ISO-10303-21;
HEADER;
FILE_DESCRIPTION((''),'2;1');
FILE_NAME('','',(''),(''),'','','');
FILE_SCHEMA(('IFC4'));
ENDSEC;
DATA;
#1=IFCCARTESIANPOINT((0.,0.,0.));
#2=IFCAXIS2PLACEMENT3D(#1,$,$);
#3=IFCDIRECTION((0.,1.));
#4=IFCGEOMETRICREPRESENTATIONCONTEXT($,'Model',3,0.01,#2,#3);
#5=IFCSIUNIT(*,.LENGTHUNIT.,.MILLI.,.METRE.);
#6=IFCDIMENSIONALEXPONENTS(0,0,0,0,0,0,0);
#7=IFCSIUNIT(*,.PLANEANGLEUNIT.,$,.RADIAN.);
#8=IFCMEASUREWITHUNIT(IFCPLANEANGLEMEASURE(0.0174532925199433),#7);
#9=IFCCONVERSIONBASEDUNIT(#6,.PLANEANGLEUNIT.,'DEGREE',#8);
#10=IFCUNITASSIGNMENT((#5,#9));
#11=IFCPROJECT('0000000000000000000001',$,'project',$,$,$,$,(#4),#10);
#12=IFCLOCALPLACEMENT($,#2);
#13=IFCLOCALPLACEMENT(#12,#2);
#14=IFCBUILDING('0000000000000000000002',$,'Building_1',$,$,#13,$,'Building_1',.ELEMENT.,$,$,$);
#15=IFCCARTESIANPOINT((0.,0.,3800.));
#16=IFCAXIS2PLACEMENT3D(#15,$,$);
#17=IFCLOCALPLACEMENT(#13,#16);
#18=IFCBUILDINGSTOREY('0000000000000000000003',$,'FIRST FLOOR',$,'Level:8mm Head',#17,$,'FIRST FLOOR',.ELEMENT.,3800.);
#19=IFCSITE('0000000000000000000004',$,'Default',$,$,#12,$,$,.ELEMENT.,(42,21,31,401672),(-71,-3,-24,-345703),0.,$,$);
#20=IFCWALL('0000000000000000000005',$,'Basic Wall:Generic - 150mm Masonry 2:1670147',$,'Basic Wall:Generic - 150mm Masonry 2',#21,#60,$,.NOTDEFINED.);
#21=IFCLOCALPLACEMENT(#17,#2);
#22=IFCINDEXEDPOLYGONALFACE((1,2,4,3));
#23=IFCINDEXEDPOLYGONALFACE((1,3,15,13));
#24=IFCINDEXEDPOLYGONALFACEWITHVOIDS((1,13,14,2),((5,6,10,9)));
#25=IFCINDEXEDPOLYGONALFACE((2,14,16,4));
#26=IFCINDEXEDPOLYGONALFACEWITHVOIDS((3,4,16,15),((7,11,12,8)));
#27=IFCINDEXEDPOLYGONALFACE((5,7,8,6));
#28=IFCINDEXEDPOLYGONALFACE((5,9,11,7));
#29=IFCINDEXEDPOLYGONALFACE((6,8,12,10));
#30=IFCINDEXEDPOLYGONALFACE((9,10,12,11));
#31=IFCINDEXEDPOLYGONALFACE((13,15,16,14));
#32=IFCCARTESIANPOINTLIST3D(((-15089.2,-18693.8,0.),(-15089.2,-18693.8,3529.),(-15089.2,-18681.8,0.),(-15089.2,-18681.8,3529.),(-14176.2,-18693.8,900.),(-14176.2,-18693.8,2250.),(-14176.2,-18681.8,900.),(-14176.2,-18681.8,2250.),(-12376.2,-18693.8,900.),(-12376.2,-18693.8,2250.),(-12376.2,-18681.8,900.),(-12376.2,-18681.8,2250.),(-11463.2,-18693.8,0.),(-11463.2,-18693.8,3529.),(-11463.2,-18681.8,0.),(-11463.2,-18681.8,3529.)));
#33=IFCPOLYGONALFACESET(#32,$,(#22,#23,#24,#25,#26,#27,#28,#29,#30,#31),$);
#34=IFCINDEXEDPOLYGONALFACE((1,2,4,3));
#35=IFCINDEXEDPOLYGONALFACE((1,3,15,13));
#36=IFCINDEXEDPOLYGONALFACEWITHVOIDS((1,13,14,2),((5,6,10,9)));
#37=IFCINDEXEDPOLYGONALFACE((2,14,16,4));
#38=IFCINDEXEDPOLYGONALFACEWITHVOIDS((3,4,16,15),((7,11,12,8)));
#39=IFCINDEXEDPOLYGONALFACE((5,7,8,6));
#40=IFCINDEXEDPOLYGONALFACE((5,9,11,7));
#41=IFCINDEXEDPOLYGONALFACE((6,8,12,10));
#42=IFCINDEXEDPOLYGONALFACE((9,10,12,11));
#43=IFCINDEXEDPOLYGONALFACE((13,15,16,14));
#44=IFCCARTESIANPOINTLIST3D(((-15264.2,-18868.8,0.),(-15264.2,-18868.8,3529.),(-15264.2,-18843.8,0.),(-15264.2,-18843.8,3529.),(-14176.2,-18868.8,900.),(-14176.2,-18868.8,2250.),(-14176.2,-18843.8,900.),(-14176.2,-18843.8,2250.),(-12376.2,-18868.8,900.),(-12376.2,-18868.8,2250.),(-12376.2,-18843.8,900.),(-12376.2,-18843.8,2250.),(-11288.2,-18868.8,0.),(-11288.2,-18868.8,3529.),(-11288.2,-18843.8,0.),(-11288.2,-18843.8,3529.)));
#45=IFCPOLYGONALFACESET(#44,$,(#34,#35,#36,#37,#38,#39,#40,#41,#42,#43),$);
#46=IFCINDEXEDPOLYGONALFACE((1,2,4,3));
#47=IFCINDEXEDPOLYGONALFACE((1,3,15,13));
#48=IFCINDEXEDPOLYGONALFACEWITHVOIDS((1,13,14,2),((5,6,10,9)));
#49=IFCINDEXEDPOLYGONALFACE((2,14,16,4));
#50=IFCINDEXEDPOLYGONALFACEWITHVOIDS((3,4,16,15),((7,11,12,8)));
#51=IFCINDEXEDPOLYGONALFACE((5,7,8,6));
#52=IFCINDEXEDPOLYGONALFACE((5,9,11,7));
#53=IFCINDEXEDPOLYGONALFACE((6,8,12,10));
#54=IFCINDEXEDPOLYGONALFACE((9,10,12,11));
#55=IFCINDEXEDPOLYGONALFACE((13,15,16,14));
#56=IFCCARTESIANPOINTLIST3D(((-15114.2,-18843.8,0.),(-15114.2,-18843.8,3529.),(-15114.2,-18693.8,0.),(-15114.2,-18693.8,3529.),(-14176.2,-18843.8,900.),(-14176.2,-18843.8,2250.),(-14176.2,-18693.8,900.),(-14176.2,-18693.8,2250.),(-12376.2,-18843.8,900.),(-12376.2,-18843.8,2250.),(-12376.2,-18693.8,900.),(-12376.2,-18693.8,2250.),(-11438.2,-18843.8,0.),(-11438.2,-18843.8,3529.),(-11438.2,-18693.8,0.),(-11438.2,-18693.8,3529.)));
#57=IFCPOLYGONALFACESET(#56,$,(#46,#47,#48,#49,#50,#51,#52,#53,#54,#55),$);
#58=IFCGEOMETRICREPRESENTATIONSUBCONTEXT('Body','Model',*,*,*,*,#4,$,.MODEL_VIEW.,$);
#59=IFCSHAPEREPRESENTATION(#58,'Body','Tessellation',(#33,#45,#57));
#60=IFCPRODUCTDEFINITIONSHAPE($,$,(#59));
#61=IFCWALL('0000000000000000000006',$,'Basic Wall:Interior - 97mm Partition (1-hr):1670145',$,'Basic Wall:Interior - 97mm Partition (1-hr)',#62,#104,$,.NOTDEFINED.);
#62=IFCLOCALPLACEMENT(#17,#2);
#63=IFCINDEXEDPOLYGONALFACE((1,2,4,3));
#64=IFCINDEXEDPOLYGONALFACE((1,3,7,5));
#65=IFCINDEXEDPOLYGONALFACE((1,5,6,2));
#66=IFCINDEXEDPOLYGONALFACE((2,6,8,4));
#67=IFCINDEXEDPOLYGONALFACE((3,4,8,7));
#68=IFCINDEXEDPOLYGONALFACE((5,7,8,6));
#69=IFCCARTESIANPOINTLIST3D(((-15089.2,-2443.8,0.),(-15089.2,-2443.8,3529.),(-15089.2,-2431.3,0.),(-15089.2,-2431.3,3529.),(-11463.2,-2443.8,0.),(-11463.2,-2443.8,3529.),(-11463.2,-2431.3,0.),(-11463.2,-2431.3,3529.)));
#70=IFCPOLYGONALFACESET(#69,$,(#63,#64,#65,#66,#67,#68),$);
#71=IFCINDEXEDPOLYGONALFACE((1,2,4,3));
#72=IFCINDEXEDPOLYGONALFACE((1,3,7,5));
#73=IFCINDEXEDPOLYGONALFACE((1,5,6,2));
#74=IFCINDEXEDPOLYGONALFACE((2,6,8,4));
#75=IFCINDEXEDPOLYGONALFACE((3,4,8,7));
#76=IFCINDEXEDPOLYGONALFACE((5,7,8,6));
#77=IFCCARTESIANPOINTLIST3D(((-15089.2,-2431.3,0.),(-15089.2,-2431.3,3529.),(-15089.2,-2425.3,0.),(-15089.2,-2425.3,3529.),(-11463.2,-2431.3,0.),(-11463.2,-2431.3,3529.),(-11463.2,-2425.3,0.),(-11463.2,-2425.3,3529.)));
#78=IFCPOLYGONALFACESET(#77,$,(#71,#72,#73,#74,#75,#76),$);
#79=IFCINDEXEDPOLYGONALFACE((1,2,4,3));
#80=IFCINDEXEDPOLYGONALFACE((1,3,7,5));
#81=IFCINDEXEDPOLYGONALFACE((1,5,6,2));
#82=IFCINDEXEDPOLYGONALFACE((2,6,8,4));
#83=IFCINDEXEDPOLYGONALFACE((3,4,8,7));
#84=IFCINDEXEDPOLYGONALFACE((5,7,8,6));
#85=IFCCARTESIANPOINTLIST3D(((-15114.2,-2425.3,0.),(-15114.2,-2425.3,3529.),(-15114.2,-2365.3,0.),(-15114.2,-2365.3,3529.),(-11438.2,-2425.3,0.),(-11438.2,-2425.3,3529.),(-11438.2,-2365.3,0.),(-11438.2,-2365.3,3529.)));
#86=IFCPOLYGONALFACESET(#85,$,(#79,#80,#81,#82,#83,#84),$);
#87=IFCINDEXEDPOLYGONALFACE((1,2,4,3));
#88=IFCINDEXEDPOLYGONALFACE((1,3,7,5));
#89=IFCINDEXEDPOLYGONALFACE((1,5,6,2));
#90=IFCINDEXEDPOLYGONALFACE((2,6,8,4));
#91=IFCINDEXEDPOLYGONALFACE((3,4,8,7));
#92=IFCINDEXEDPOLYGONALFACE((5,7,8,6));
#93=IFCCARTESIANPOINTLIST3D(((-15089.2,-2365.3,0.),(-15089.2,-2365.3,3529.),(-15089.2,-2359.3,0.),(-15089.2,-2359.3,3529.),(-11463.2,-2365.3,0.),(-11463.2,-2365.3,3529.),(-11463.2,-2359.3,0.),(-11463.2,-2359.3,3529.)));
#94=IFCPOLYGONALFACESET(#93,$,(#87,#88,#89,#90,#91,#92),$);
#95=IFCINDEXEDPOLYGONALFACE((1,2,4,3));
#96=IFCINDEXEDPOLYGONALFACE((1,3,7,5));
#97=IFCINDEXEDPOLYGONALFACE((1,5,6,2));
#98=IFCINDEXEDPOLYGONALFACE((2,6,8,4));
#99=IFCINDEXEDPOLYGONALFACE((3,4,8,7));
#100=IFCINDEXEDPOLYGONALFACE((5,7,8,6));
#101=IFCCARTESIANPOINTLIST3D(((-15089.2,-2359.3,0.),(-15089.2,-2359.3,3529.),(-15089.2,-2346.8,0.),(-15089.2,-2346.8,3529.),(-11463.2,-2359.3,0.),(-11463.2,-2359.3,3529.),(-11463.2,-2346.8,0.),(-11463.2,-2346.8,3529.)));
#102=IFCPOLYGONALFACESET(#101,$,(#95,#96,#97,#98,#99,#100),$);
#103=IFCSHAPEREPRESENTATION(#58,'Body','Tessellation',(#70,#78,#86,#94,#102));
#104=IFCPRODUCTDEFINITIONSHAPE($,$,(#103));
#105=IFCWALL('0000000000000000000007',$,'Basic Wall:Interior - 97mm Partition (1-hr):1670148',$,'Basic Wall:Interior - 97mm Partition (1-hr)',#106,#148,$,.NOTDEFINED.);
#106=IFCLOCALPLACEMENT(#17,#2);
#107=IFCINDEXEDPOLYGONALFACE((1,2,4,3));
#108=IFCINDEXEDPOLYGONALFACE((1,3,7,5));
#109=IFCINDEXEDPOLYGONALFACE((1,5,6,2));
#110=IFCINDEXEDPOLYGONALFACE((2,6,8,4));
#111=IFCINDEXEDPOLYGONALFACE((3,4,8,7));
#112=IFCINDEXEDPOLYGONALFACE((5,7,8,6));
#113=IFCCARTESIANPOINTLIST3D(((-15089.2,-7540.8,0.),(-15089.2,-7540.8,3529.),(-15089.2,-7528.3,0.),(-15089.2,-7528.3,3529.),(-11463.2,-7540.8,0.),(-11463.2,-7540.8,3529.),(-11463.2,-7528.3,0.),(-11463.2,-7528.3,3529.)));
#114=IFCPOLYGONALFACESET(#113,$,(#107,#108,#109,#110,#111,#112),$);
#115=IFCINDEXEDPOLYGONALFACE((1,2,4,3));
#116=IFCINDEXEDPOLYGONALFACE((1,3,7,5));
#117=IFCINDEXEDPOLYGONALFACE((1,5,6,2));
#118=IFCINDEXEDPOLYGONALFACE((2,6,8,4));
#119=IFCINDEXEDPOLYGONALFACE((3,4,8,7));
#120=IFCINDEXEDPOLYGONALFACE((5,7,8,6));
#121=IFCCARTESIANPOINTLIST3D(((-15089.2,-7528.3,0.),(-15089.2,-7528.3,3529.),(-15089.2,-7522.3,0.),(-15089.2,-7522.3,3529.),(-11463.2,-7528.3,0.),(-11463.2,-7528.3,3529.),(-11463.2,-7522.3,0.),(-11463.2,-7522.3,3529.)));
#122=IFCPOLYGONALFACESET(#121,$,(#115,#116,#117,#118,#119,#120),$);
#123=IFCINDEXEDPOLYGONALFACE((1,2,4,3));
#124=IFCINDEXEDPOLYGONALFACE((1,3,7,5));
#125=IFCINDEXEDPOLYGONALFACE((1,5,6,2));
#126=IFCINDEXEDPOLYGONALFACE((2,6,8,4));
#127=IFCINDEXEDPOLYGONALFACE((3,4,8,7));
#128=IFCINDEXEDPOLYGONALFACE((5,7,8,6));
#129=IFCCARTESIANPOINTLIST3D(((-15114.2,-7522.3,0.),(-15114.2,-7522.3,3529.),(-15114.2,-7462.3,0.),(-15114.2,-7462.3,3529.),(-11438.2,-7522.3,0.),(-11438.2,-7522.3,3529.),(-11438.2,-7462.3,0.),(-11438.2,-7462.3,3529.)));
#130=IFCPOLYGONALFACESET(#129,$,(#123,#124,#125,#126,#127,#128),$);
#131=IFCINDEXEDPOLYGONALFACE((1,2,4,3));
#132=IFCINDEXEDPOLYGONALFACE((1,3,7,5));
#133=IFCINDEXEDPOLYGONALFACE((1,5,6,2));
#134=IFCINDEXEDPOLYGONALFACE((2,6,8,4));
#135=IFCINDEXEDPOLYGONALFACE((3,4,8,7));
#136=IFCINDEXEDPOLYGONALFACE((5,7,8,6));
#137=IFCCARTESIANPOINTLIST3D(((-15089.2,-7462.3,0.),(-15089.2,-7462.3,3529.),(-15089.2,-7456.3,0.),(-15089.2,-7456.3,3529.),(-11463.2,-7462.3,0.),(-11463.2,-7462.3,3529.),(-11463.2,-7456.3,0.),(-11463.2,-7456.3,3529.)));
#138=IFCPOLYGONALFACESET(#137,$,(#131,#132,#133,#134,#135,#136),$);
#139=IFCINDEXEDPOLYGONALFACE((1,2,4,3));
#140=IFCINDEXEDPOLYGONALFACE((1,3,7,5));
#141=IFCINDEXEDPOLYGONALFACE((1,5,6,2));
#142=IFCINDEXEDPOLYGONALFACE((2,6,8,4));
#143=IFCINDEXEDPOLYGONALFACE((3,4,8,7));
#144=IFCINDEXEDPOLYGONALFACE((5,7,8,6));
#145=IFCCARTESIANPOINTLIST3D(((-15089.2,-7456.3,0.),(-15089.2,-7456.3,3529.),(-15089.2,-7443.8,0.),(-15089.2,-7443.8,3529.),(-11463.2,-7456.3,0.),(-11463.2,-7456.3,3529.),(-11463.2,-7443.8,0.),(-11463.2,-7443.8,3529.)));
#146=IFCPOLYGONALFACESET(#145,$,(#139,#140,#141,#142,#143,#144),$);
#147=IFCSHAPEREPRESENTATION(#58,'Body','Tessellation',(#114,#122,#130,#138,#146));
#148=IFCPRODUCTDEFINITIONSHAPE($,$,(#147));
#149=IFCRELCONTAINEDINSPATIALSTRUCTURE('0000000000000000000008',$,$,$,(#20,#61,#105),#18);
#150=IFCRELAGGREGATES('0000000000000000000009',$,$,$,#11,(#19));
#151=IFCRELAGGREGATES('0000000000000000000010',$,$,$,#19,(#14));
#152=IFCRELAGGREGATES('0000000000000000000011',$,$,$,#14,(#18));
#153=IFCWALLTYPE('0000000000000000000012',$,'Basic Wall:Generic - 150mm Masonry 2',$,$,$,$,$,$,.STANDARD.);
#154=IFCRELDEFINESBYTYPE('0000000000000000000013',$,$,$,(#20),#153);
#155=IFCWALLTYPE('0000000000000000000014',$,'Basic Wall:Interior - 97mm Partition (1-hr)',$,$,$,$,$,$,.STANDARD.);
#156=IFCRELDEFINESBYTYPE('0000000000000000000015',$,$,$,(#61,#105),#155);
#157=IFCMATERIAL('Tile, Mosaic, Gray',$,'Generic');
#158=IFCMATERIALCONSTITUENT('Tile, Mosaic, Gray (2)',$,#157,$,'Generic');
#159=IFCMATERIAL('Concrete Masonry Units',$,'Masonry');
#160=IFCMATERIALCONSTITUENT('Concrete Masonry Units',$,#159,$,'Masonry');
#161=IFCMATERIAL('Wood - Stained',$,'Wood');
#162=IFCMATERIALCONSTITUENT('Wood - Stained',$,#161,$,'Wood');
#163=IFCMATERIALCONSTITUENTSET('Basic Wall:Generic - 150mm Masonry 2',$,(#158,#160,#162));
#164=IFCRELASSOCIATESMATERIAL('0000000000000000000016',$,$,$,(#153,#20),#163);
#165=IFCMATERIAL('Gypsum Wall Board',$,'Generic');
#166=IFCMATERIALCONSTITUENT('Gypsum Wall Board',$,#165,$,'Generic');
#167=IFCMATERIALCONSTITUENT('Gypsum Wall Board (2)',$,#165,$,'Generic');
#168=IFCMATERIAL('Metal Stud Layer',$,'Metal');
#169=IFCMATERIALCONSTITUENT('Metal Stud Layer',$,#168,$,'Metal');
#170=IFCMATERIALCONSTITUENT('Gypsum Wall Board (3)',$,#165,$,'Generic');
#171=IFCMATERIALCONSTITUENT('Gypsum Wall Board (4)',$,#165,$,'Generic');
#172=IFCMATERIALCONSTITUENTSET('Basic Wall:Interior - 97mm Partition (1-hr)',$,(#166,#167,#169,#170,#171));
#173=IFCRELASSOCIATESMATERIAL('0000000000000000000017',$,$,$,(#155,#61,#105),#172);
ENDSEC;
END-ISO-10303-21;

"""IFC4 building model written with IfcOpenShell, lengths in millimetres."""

from ifc_helpers import new_model, entity, si_unit, converted_unit, direction, frame, origin, place, context, subcontext, project, spatial, indexed_curve, outline, extrude, material, constituent, constituent_set, type_object, element, save


model = new_model("IFC4")

# Units and contexts
model_context = context("Model", 3, precision=0.01, world=origin(), true_north=direction((0.0, 1.0)))
body_context = subcontext(model_context, "Body", "Model", "MODEL_VIEW")
ifc_project = project(units=[si_unit("LENGTHUNIT", "METRE", prefix="MILLI"), converted_unit("PLANEANGLEUNIT", "DEGREE", entity("IfcPlaneAngleMeasure", 0.0174532925199433), si_unit("PLANEANGLEUNIT", "RADIAN"), dimensions=[0, 0, 0, 0, 0, 0, 0])], contexts=[model_context])

# Site, building, storey
site_placement = place(None, origin())
site = spatial("IfcSite", under=ifc_project, at=site_placement, Name="Default", CompositionType="ELEMENT", RefLatitude=(42, 21, 31, 401672), RefLongitude=(-71, -3, -24, -345703), RefElevation=0.0)
building_placement = place(site_placement, origin())
building = spatial("IfcBuilding", under=site, at=building_placement, Name="Building_1", LongName="Building_1", CompositionType="ELEMENT")
storey_placement = place(building_placement, frame((0.0, 0.0, 3800.0)))
storey = spatial("IfcBuildingStorey", under=building, at=storey_placement, Name="FIRST FLOOR", ObjectType="Level:8mm Head", LongName="FIRST FLOOR", CompositionType="ELEMENT", Elevation=3800.0)

# Shared definitions
ifc_material_1 = material(Name="Tile, Mosaic, Gray", Category="Generic")
ifc_constituent_1 = constituent(ifc_material_1, Name="Tile, Mosaic, Gray (2)", Category="Generic")
ifc_material_2 = material(Name="Concrete Masonry Units", Category="Masonry")
ifc_constituent_2 = constituent(ifc_material_2, Name="Concrete Masonry Units", Category="Masonry")
ifc_material_3 = material(Name="Wood - Stained", Category="Wood")
ifc_constituent_3 = constituent(ifc_material_3, Name="Wood - Stained", Category="Wood")
ifc_constituent_set_1 = constituent_set(constituents=[ifc_constituent_1, ifc_constituent_2, ifc_constituent_3], Name="Basic Wall:Generic - 150mm Masonry 2")
wall_type_1 = type_object("IfcWallType", Name="Basic Wall:Generic - 150mm Masonry 2", PredefinedType="STANDARD", material=ifc_constituent_set_1)

# Wall, opening
wall_1_placement = place(storey_placement, frame((-11463.2, -18775.3, 0.0), z_axis=(0.0, 0.0, 1.0), x_axis=(-1.0, 0.0, 0.0)))
wall_1 = element("IfcWall", 1, at=wall_1_placement, inside=storey, type_object=wall_type_1, material=ifc_constituent_set_1, Name="Basic Wall:Generic - 150mm Masonry 2:1670147", ObjectType="Basic Wall:Generic - 150mm Masonry 2", PredefinedType="NOTDEFINED", context=body_context, shape_type="SweptSolid", body=[
    extrude(outline(indexed_curve([(-1764.5, -1813.0), (1764.5, -1813.0), (1764.5, 1813.0), (-1764.5, 1813.0), (-1764.5, -1813.0)], self_intersect=False), holes=[indexed_curve([(-864.5, -900.0), (-864.5, 900.0), (485.5, 900.0), (485.5, -900.0), (-864.5, -900.0)], self_intersect=False)]), frame((1813.0, -81.5, 1764.5), z_axis=(0.0, -1.0, 0.0), x_axis=(0.0, 0.0, 1.0)), (0.0, 0.0, 1.0), 12.0),
    extrude(outline(indexed_curve([(-1988.0, -1764.5), (1988.0, -1764.5), (1988.0, 1764.5), (-1988.0, 1764.5), (-1988.0, -1764.5)], self_intersect=False), holes=[indexed_curve([(900.0, 485.5), (900.0, -864.5), (-900.0, -864.5), (-900.0, 485.5), (900.0, 485.5)], self_intersect=False)]), frame((1813.0, 93.5, 1764.5), z_axis=(0.0, -1.0, 0.0), x_axis=(1.0, 0.0, 0.0)), (0.0, 0.0, 1.0), 25.0),
    extrude(outline(indexed_curve([(-1764.5, -1838.0), (1764.5, -1838.0), (1764.5, 1838.0), (-1764.5, 1838.0), (-1764.5, -1838.0)], self_intersect=False), holes=[indexed_curve([(-864.5, -900.0), (-864.5, 900.0), (485.5, 900.0), (485.5, -900.0), (-864.5, -900.0)], self_intersect=False)]), frame((1813.0, 68.5, 1764.5), z_axis=(0.0, -1.0, 0.0), x_axis=(0.0, 0.0, 1.0)), (0.0, 0.0, 1.0), 150.0),
])
opening_placement = place(wall_1_placement, frame((913.0, -93.5, 900.0)))
element("IfcOpeningElement", 2, at=opening_placement, cuts=wall_1, PredefinedType="OPENING", context=body_context, shape_type="SweptSolid", body=[
    extrude(outline(indexed_curve([(1350.0, 1800.0), (0.0, 1800.0), (0.0, 0.0), (1350.0, 0.0), (1350.0, 1800.0)], self_intersect=False)), frame((0.0, 0.0, 0.0), z_axis=(0.0, 1.0, 0.0), x_axis=(0.0, 0.0, 1.0)), (0.0, 0.0, 1.0), 187.0),
])

# Walls
ifc_material_4 = material(Name="Gypsum Wall Board", Category="Generic")
ifc_constituent_4 = constituent(ifc_material_4, Name="Gypsum Wall Board", Category="Generic")
ifc_constituent_5 = constituent(ifc_material_4, Name="Gypsum Wall Board (2)", Category="Generic")
ifc_material_5 = material(Name="Metal Stud Layer", Category="Metal")
ifc_constituent_6 = constituent(ifc_material_5, Name="Metal Stud Layer", Category="Metal")
ifc_constituent_7 = constituent(ifc_material_4, Name="Gypsum Wall Board (3)", Category="Generic")
ifc_constituent_8 = constituent(ifc_material_4, Name="Gypsum Wall Board (4)", Category="Generic")
ifc_constituent_set_2 = constituent_set(constituents=[ifc_constituent_4, ifc_constituent_5, ifc_constituent_6, ifc_constituent_7, ifc_constituent_8], Name="Basic Wall:Interior - 97mm Partition (1-hr)")
wall_type_2 = type_object("IfcWallType", Name="Basic Wall:Interior - 97mm Partition (1-hr)", PredefinedType="STANDARD", material=ifc_constituent_set_2)
wall_2_placement = place(storey_placement, frame((-15089.2, -2395.3, 0.0)))
element("IfcWall", 3, at=wall_2_placement, inside=storey, type_object=wall_type_2, material=ifc_constituent_set_2, Name="Basic Wall:Interior - 97mm Partition (1-hr):1670145", ObjectType="Basic Wall:Interior - 97mm Partition (1-hr)", PredefinedType="NOTDEFINED", context=body_context, shape_type="SweptSolid", body=[
    extrude(outline(indexed_curve([(-6.3, -1813.0), (6.2, -1813.0), (6.3, 1813.0), (-6.2, 1813.0), (-6.3, -1813.0)], self_intersect=False)), frame((1813.0, -42.2, 0.0), z_axis=(0.0, 0.0, 1.0), x_axis=(0.0, 1.0, 0.0)), (0.0, 0.0, 1.0), 3529.0),
    extrude(outline(indexed_curve([(-1813.0, -3.0), (1813.0, -3.0), (1813.0, 3.0), (-1813.0, 3.0), (-1813.0, -3.0)], self_intersect=False)), frame((1813.0, -33.0, 0.0)), (0.0, 0.0, 1.0), 3529.0),
    extrude(outline(indexed_curve([(-1838.0, -30.0), (1838.0, -30.0), (1838.0, 30.0), (-1838.0, 30.0), (-1838.0, -30.0)], self_intersect=False)), frame((1813.0, 0.0, 0.0)), (0.0, 0.0, 1.0), 3529.0),
    extrude(outline(indexed_curve([(-1813.0, -3.0), (1813.0, -3.0), (1813.0, 3.0), (-1813.0, 3.0), (-1813.0, -3.0)], self_intersect=False)), frame((1813.0, 33.0, 0.0)), (0.0, 0.0, 1.0), 3529.0),
    extrude(outline(indexed_curve([(-6.3, -1813.0), (6.2, -1813.0), (6.3, 1813.0), (-6.2, 1813.0), (-6.3, -1813.0)], self_intersect=False)), frame((1813.0, 42.3, 0.0), z_axis=(0.0, 0.0, 1.0), x_axis=(0.0, -1.0, 0.0)), (0.0, 0.0, 1.0), 3529.0),
])
wall_3_placement = place(storey_placement, frame((-15089.2, -7492.3, 0.0)))
element("IfcWall", 4, at=wall_3_placement, inside=storey, type_object=wall_type_2, material=ifc_constituent_set_2, Name="Basic Wall:Interior - 97mm Partition (1-hr):1670148", ObjectType="Basic Wall:Interior - 97mm Partition (1-hr)", PredefinedType="NOTDEFINED", context=body_context, shape_type="SweptSolid", body=[
    extrude(outline(indexed_curve([(-6.3, -1813.0), (6.2, -1813.0), (6.3, 1813.0), (-6.2, 1813.0), (-6.3, -1813.0)], self_intersect=False)), frame((1813.0, -42.2, 0.0), z_axis=(0.0, 0.0, 1.0), x_axis=(0.0, 1.0, 0.0)), (0.0, 0.0, 1.0), 3529.0),
    extrude(outline(indexed_curve([(-1813.0, -3.0), (1813.0, -3.0), (1813.0, 3.0), (-1813.0, 3.0), (-1813.0, -3.0)], self_intersect=False)), frame((1813.0, -33.0, 0.0)), (0.0, 0.0, 1.0), 3529.0),
    extrude(outline(indexed_curve([(-1838.0, -30.0), (1838.0, -30.0), (1838.0, 30.0), (-1838.0, 30.0), (-1838.0, -30.0)], self_intersect=False)), frame((1813.0, 0.0, 0.0)), (0.0, 0.0, 1.0), 3529.0),
    extrude(outline(indexed_curve([(-1813.0, -3.0), (1813.0, -3.0), (1813.0, 3.0), (-1813.0, 3.0), (-1813.0, -3.0)], self_intersect=False)), frame((1813.0, 33.0, 0.0)), (0.0, 0.0, 1.0), 3529.0),
    extrude(outline(indexed_curve([(-6.3, -1813.0), (6.2, -1813.0), (6.3, 1813.0), (-6.2, 1813.0), (-6.3, -1813.0)], self_intersect=False)), frame((1813.0, 42.3, 0.0), z_axis=(0.0, 0.0, 1.0), x_axis=(0.0, -1.0, 0.0)), (0.0, 0.0, 1.0), 3529.0),
])

save(model, "model.ifc")
